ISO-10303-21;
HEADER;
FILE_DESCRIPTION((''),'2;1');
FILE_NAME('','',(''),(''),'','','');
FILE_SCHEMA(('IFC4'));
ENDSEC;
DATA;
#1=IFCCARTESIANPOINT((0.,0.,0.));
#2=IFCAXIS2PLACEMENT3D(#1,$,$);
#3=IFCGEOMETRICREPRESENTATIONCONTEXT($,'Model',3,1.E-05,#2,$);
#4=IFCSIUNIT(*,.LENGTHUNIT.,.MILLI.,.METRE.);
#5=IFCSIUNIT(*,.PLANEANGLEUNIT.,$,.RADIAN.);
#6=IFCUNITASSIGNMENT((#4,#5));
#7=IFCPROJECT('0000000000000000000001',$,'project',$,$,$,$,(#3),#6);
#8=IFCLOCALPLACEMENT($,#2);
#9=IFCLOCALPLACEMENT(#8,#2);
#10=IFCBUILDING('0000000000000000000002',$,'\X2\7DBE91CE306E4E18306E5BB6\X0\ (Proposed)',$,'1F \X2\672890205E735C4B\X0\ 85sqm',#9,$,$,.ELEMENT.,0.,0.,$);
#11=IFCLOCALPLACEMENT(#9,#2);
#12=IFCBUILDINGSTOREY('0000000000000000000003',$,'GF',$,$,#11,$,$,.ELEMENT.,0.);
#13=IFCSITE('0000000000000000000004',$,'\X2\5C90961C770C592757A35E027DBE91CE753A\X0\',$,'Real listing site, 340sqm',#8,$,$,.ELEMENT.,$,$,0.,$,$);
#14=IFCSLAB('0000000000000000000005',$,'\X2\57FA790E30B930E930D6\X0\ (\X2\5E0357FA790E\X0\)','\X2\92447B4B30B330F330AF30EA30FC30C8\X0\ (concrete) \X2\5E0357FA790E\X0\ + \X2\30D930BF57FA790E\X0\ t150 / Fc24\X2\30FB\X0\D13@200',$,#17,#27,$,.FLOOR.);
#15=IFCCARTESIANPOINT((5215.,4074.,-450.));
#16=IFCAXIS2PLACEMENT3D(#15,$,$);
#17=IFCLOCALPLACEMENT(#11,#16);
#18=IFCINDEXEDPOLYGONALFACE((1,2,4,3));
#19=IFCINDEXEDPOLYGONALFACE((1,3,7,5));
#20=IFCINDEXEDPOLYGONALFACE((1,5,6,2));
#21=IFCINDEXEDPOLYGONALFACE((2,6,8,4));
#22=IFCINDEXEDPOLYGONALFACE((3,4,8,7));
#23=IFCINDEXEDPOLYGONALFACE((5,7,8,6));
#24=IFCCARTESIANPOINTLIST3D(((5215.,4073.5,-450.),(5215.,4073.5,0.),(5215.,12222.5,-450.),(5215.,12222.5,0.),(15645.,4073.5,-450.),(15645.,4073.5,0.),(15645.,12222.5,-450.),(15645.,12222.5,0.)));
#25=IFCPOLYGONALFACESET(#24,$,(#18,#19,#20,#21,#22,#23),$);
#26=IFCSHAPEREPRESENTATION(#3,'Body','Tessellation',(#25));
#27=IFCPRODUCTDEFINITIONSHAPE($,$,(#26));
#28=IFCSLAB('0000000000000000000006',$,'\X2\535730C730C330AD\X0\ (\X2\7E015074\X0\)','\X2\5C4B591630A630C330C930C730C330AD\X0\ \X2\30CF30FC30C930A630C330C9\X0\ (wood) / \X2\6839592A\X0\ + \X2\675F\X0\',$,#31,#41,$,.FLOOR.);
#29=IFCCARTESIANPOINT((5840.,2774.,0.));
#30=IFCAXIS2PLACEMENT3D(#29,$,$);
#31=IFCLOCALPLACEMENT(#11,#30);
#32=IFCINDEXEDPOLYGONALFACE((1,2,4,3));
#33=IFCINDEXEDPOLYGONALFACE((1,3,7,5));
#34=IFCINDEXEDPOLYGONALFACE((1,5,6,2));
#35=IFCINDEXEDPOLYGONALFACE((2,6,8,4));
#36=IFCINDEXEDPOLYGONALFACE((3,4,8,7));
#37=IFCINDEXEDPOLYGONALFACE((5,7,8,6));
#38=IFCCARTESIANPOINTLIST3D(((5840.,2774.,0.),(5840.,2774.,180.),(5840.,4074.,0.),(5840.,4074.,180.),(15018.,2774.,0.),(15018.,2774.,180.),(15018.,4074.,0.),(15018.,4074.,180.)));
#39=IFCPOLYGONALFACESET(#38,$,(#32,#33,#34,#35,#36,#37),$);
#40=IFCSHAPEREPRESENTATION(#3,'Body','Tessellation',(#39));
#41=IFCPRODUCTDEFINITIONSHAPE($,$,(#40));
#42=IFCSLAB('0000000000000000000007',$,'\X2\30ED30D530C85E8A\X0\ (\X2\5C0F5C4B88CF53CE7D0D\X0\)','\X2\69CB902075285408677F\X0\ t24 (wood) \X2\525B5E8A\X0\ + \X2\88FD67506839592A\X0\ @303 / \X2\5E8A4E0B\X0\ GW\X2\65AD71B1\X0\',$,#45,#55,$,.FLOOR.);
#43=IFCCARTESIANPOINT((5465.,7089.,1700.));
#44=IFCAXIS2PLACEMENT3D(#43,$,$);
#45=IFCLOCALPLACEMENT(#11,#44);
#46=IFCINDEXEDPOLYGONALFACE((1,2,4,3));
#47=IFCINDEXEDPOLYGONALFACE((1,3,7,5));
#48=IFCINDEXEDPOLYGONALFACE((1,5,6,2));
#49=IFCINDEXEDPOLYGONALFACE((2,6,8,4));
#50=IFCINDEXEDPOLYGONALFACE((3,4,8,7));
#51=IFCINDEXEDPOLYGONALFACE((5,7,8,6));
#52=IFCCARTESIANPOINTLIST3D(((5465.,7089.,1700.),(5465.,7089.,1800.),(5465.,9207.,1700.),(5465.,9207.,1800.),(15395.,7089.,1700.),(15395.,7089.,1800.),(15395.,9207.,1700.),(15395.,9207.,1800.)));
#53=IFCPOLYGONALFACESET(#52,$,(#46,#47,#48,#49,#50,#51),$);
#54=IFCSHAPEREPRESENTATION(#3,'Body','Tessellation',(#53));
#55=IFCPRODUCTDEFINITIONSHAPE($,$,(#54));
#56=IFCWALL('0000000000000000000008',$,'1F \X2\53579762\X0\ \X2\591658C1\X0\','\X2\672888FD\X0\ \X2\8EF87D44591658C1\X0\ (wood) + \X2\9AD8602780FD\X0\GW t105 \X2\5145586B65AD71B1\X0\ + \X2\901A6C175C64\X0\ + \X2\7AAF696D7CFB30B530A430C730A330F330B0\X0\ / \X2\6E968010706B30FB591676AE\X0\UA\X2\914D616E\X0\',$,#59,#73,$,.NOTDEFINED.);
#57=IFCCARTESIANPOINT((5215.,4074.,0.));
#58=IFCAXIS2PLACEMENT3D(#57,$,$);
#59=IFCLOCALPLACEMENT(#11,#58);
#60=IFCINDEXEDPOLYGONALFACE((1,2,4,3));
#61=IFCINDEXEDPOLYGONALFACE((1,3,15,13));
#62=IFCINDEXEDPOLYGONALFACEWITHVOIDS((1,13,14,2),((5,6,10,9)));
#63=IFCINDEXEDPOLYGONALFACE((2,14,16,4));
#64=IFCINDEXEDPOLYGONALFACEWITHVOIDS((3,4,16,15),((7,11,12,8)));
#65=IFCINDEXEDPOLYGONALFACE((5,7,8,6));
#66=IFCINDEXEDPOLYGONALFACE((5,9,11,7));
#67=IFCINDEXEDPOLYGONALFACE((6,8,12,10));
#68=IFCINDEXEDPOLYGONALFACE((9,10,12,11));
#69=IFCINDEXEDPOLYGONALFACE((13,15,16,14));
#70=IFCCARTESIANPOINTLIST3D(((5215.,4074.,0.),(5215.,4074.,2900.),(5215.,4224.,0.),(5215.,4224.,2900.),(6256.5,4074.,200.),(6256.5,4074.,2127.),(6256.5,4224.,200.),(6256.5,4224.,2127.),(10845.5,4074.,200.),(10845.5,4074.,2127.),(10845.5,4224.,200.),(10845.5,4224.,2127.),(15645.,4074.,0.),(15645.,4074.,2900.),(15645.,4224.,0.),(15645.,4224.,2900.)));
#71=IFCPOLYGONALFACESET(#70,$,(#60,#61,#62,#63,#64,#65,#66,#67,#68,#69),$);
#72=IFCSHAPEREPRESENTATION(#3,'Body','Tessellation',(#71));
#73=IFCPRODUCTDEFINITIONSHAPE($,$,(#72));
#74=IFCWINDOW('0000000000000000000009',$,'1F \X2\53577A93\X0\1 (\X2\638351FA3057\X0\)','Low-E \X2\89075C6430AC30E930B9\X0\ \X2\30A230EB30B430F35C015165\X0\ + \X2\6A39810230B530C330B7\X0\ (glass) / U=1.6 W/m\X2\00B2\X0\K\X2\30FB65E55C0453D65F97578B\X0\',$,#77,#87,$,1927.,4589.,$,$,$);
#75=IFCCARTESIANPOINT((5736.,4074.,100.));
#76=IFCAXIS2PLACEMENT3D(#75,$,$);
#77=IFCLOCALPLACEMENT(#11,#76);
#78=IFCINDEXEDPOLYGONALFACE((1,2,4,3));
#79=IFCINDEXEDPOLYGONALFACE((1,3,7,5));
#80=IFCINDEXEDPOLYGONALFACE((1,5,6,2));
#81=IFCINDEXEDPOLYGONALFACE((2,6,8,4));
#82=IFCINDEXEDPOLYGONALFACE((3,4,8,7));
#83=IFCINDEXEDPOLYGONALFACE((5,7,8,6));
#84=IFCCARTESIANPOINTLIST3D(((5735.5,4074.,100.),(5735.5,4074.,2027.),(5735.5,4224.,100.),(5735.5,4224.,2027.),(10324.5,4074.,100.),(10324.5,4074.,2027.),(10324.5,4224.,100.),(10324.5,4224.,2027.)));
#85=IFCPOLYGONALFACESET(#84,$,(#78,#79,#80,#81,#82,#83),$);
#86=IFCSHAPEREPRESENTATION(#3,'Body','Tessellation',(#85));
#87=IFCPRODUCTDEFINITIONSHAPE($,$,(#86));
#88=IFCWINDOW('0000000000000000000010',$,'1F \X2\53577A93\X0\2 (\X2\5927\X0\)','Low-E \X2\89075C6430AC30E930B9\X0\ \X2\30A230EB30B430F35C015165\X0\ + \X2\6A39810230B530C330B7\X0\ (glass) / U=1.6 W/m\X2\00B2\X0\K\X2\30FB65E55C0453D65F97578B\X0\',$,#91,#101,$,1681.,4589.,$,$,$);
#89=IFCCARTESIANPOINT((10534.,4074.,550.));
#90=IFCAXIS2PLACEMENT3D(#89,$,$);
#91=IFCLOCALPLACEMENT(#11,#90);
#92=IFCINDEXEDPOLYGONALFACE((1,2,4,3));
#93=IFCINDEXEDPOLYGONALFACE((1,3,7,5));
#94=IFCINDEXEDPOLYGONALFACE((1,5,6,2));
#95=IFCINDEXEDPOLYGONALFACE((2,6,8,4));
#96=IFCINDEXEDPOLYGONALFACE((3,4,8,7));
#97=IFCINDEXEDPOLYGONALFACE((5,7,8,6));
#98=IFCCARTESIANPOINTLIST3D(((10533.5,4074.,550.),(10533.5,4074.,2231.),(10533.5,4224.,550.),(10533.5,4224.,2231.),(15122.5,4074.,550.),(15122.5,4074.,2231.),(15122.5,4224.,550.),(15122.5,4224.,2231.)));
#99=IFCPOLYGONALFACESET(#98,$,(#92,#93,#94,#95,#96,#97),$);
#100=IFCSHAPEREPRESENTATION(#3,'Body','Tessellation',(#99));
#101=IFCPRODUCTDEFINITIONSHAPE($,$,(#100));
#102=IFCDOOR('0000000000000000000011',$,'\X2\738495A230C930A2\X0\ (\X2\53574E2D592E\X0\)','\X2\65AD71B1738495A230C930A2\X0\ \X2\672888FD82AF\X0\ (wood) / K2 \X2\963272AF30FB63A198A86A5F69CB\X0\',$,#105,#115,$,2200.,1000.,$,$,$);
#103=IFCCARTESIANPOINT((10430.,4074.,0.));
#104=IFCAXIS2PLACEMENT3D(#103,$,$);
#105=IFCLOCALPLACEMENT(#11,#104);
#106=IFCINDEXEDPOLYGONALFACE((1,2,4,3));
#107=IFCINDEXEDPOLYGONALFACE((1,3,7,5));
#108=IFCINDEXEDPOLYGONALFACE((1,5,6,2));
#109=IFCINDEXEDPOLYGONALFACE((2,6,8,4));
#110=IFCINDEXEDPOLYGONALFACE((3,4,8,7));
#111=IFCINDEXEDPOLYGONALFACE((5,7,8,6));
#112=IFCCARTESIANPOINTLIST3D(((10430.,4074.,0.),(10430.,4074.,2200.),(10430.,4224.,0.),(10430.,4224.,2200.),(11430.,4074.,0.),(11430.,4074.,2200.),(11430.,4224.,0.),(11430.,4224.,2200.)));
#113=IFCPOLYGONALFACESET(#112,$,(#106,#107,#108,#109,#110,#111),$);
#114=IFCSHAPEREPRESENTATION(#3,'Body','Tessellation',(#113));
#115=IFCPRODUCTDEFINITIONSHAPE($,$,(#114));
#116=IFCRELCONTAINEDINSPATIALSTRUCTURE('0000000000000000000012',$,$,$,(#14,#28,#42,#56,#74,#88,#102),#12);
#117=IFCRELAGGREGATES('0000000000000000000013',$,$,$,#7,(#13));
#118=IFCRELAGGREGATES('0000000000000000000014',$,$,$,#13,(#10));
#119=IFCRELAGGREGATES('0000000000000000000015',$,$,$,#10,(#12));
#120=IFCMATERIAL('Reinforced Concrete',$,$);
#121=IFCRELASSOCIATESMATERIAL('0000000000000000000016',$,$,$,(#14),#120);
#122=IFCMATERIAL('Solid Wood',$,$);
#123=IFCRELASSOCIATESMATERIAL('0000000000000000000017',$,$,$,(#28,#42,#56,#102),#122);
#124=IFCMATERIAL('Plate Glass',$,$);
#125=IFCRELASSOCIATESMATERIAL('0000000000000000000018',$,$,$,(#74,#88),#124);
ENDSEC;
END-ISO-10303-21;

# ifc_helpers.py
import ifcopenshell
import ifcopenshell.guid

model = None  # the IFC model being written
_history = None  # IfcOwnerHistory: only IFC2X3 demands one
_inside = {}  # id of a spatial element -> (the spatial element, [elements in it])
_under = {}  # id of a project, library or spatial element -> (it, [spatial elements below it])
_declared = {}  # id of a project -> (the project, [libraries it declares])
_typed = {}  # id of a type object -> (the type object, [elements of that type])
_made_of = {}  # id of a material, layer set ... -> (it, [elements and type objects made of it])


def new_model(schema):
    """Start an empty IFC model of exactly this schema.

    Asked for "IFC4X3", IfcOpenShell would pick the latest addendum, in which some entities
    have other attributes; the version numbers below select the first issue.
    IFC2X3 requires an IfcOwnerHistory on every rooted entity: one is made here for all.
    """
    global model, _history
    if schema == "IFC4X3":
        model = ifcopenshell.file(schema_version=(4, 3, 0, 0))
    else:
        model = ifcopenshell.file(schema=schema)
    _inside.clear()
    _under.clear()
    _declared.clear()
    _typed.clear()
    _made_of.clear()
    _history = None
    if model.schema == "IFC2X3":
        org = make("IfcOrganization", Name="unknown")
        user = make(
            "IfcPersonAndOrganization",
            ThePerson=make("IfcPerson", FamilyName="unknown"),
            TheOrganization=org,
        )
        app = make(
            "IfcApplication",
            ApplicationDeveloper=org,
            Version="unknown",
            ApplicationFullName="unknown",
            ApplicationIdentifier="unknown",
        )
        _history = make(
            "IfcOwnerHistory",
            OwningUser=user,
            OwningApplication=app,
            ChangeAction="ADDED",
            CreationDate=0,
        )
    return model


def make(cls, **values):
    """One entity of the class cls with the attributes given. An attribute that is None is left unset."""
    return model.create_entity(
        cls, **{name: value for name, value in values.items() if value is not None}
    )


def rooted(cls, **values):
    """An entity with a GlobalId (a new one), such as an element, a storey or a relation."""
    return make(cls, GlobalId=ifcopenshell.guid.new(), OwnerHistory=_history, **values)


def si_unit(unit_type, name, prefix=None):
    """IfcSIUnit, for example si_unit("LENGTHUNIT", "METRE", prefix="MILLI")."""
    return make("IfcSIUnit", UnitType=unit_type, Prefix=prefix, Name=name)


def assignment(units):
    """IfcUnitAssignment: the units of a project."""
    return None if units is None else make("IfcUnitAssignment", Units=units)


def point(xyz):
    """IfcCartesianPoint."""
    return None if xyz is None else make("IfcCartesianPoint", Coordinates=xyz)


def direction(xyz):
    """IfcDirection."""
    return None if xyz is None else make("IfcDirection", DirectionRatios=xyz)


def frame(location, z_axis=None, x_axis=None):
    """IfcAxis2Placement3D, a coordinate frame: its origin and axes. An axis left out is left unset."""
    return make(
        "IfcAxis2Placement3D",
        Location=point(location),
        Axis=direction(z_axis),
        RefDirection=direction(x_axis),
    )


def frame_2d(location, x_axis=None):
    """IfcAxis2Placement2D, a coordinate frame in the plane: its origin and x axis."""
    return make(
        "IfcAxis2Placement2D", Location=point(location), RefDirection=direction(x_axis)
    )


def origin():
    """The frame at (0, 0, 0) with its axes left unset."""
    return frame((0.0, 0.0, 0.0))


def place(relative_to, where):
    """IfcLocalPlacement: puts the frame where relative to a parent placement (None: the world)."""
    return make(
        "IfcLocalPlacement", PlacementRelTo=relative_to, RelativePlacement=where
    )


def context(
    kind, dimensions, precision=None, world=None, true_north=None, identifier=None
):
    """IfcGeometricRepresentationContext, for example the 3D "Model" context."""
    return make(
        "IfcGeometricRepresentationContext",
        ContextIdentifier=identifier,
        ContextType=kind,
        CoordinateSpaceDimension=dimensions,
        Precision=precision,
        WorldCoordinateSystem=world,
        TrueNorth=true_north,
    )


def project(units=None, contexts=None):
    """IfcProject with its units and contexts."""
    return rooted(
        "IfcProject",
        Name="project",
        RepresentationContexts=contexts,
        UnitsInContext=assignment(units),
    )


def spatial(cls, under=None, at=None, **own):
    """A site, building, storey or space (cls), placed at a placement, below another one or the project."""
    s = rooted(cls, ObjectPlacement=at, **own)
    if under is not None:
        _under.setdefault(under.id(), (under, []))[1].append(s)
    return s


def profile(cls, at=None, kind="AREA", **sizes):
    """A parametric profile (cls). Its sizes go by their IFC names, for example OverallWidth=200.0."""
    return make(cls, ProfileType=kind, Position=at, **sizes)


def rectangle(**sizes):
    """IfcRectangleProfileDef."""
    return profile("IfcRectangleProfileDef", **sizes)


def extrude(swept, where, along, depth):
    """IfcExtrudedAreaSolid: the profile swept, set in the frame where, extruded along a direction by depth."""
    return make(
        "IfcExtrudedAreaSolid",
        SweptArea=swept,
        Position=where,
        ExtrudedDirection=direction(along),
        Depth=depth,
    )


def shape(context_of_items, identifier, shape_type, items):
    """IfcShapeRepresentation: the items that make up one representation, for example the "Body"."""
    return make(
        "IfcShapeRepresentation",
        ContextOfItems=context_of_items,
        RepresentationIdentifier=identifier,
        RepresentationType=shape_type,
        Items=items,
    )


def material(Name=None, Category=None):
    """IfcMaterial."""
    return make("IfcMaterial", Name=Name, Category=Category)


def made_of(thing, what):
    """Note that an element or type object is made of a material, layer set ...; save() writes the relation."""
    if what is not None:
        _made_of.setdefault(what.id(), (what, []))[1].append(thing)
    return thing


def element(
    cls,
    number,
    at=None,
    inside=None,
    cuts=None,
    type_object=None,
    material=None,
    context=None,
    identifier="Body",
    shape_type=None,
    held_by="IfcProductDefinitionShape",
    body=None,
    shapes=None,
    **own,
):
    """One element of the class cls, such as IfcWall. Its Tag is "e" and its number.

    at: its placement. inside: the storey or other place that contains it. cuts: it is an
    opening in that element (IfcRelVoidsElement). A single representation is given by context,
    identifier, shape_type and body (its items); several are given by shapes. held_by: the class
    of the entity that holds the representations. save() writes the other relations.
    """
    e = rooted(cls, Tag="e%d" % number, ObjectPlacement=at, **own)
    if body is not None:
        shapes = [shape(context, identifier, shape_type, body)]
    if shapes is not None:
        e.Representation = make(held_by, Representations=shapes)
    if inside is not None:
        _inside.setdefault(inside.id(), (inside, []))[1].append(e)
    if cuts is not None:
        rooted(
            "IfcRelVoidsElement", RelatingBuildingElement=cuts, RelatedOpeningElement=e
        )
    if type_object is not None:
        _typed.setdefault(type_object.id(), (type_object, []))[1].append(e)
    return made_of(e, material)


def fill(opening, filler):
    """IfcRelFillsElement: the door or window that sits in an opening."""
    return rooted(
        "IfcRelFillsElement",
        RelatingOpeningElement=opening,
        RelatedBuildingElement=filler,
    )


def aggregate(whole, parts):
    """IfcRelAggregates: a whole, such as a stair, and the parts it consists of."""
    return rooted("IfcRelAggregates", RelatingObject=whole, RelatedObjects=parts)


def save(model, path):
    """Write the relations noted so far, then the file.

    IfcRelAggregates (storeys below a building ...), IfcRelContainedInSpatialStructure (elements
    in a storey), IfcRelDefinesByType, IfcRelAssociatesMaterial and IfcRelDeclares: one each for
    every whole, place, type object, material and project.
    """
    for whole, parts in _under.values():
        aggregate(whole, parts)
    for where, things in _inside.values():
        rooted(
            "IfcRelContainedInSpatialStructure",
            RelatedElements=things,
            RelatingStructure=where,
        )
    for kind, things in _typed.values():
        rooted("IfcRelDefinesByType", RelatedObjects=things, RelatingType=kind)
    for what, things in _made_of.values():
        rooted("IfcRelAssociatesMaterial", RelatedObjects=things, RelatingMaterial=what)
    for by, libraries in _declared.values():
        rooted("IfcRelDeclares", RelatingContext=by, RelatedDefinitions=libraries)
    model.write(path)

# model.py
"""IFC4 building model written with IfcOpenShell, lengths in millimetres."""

from ifc_helpers import new_model, si_unit, frame, frame_2d, origin, place, context, project, spatial, rectangle, extrude, material, element, fill, save


model = new_model("IFC4")

# Units and contexts
model_context = context("Model", 3, precision=1e-05, world=origin())
ifc_project = project(units=[si_unit("LENGTHUNIT", "METRE", prefix="MILLI"), si_unit("PLANEANGLEUNIT", "RADIAN")], contexts=[model_context])

# Site, building, storey
site_placement = place(None, origin())
site = spatial("IfcSite", under=ifc_project, at=site_placement, Name="岐阜県大垣市綾野町", ObjectType="Real listing site, 340sqm", CompositionType="ELEMENT", RefElevation=0.0)
building_placement = place(site_placement, origin())
building = spatial("IfcBuilding", under=site, at=building_placement, Name="綾野の丘の家 (Proposed)", ObjectType="1F 木造平屋 85sqm", CompositionType="ELEMENT", ElevationOfRefHeight=0.0, ElevationOfTerrain=0.0)
storey_placement = place(building_placement, origin())
storey = spatial("IfcBuildingStorey", under=building, at=storey_placement, Name="GF", CompositionType="ELEMENT", Elevation=0.0)

# Slabs
ifc_material_1 = material(Name="Reinforced Concrete")
slab_1_placement = place(storey_placement, frame((5215.0, 4074.0, -450.0)))
element("IfcSlab", 1, at=slab_1_placement, inside=storey, material=ifc_material_1, Name="基礎スラブ (布基礎)", Description="鉄筋コンクリート (concrete) 布基礎 + ベタ基礎 t150 / Fc24・D13@200", PredefinedType="FLOOR", context=model_context, shape_type="SweptSolid", body=[
    extrude(rectangle(XDim=10430.0, YDim=8149.0, at=frame_2d((5215.0, 4074.0))), frame((5215.0, 4074.0, -450.0)), (0.0, 0.0, 1.0), 450.0),
])
ifc_material_2 = material(Name="Solid Wood")
slab_2_placement = place(storey_placement, frame((5840.0, 2774.0, 0.0)))
element("IfcSlab", 2, at=slab_2_placement, inside=storey, material=ifc_material_2, Name="南デッキ (縁側)", Description="屋外ウッドデッキ ハードウッド (wood) / 根太 + 束", PredefinedType="FLOOR", context=model_context, shape_type="SweptSolid", body=[
    extrude(rectangle(XDim=9178.0, YDim=1300.0, at=frame_2d((4589.0, 650.0))), frame((5840.0, 2774.0, 0.0)), (0.0, 0.0, 1.0), 180.0),
])
slab_3_placement = place(storey_placement, frame((5465.0, 7089.0, 1700.0)))
element("IfcSlab", 3, at=slab_3_placement, inside=storey, material=ifc_material_2, Name="ロフト床 (小屋裏収納)", Description="構造用合板 t24 (wood) 剛床 + 製材根太 @303 / 床下 GW断熱", PredefinedType="FLOOR", context=model_context, shape_type="SweptSolid", body=[
    extrude(rectangle(XDim=9930.0, YDim=2118.0, at=frame_2d((4965.0, 1059.0))), frame((5465.0, 7089.0, 1700.0)), (0.0, 0.0, 1.0), 100.0),
])

# Wall, openings, windows, door
wall_1_placement = place(storey_placement, frame((5215.0, 4074.0, 0.0)))
wall_1 = element("IfcWall", 4, at=wall_1_placement, inside=storey, material=ifc_material_2, Name="1F 南面 外壁", Description="木製 軸組外壁 (wood) + 高性能GW t105 充填断熱 + 通気層 + 窯業系サイディング / 準耐火・外皮UA配慮", PredefinedType="NOTDEFINED", context=model_context, shape_type="SweptSolid", body=[
    extrude(rectangle(XDim=10430.0, YDim=150.0, at=frame_2d((5215.0, 75.0))), frame((5215.0, 4074.0, 0.0)), (0.0, 0.0, 1.0), 2900.0),
])
opening_1_placement = place(storey_placement, frame((5736.0, 4074.0, 100.0)))
opening_1 = element("IfcOpeningElement", 5, at=opening_1_placement, cuts=wall_1, PredefinedType="NOTDEFINED", context=model_context, shape_type="SweptSolid", body=[
    extrude(rectangle(XDim=4589.0, YDim=150.0, at=frame_2d((2294.0, 75.0))), frame((5736.0, 4074.0, 100.0)), (0.0, 0.0, 1.0), 1927.0),
])
opening_2_placement = place(storey_placement, frame((10534.0, 4074.0, 550.0)))
opening_2 = element("IfcOpeningElement", 6, at=opening_2_placement, cuts=wall_1, PredefinedType="NOTDEFINED", context=model_context, shape_type="SweptSolid", body=[
    extrude(rectangle(XDim=4589.0, YDim=150.0, at=frame_2d((2294.0, 75.0))), frame((10534.0, 4074.0, 550.0)), (0.0, 0.0, 1.0), 1681.0),
])
opening_3_placement = place(storey_placement, frame((10430.0, 4074.0, 0.0)))
opening_3 = element("IfcOpeningElement", 7, at=opening_3_placement, cuts=wall_1, PredefinedType="NOTDEFINED", context=model_context, shape_type="SweptSolid", body=[
    extrude(rectangle(XDim=1000.0, YDim=150.0, at=frame_2d((500.0, 75.0))), frame((10430.0, 4074.0, 0.0)), (0.0, 0.0, 1.0), 2200.0),
])
ifc_material_3 = material(Name="Plate Glass")
window_1_placement = place(storey_placement, frame((5736.0, 4074.0, 100.0)))
window_1 = element("IfcWindow", 8, at=window_1_placement, inside=storey, material=ifc_material_3, Name="1F 南窓1 (掃出し)", Description="Low-E 複層ガラス アルゴン封入 + 樹脂サッシ (glass) / U=1.6 W/m²K・日射取得型", OverallHeight=1927.0, OverallWidth=4589.0, context=model_context, shape_type="SweptSolid", body=[
    extrude(rectangle(XDim=4589.0, YDim=150.0, at=frame_2d((2294.0, 75.0))), frame((5736.0, 4074.0, 100.0)), (0.0, 0.0, 1.0), 1927.0),
])
fill(opening_1, window_1)
window_2_placement = place(storey_placement, frame((10534.0, 4074.0, 550.0)))
window_2 = element("IfcWindow", 9, at=window_2_placement, inside=storey, material=ifc_material_3, Name="1F 南窓2 (大)", Description="Low-E 複層ガラス アルゴン封入 + 樹脂サッシ (glass) / U=1.6 W/m²K・日射取得型", OverallHeight=1681.0, OverallWidth=4589.0, context=model_context, shape_type="SweptSolid", body=[
    extrude(rectangle(XDim=4589.0, YDim=150.0, at=frame_2d((2294.0, 75.0))), frame((10534.0, 4074.0, 550.0)), (0.0, 0.0, 1.0), 1681.0),
])
fill(opening_2, window_2)
door_1_placement = place(storey_placement, frame((10430.0, 4074.0, 0.0)))
door_1 = element("IfcDoor", 10, at=door_1_placement, inside=storey, material=ifc_material_2, Name="玄関ドア (南中央)", Description="断熱玄関ドア 木製芯 (wood) / K2 防犯・採風機構", OverallHeight=2200.0, OverallWidth=1000.0, context=model_context, shape_type="SweptSolid", body=[
    extrude(rectangle(XDim=1000.0, YDim=150.0, at=frame_2d((500.0, 75.0))), frame((10430.0, 4074.0, 0.0)), (0.0, 0.0, 1.0), 2200.0),
])
fill(opening_3, door_1)

save(model, "model.ifc")
